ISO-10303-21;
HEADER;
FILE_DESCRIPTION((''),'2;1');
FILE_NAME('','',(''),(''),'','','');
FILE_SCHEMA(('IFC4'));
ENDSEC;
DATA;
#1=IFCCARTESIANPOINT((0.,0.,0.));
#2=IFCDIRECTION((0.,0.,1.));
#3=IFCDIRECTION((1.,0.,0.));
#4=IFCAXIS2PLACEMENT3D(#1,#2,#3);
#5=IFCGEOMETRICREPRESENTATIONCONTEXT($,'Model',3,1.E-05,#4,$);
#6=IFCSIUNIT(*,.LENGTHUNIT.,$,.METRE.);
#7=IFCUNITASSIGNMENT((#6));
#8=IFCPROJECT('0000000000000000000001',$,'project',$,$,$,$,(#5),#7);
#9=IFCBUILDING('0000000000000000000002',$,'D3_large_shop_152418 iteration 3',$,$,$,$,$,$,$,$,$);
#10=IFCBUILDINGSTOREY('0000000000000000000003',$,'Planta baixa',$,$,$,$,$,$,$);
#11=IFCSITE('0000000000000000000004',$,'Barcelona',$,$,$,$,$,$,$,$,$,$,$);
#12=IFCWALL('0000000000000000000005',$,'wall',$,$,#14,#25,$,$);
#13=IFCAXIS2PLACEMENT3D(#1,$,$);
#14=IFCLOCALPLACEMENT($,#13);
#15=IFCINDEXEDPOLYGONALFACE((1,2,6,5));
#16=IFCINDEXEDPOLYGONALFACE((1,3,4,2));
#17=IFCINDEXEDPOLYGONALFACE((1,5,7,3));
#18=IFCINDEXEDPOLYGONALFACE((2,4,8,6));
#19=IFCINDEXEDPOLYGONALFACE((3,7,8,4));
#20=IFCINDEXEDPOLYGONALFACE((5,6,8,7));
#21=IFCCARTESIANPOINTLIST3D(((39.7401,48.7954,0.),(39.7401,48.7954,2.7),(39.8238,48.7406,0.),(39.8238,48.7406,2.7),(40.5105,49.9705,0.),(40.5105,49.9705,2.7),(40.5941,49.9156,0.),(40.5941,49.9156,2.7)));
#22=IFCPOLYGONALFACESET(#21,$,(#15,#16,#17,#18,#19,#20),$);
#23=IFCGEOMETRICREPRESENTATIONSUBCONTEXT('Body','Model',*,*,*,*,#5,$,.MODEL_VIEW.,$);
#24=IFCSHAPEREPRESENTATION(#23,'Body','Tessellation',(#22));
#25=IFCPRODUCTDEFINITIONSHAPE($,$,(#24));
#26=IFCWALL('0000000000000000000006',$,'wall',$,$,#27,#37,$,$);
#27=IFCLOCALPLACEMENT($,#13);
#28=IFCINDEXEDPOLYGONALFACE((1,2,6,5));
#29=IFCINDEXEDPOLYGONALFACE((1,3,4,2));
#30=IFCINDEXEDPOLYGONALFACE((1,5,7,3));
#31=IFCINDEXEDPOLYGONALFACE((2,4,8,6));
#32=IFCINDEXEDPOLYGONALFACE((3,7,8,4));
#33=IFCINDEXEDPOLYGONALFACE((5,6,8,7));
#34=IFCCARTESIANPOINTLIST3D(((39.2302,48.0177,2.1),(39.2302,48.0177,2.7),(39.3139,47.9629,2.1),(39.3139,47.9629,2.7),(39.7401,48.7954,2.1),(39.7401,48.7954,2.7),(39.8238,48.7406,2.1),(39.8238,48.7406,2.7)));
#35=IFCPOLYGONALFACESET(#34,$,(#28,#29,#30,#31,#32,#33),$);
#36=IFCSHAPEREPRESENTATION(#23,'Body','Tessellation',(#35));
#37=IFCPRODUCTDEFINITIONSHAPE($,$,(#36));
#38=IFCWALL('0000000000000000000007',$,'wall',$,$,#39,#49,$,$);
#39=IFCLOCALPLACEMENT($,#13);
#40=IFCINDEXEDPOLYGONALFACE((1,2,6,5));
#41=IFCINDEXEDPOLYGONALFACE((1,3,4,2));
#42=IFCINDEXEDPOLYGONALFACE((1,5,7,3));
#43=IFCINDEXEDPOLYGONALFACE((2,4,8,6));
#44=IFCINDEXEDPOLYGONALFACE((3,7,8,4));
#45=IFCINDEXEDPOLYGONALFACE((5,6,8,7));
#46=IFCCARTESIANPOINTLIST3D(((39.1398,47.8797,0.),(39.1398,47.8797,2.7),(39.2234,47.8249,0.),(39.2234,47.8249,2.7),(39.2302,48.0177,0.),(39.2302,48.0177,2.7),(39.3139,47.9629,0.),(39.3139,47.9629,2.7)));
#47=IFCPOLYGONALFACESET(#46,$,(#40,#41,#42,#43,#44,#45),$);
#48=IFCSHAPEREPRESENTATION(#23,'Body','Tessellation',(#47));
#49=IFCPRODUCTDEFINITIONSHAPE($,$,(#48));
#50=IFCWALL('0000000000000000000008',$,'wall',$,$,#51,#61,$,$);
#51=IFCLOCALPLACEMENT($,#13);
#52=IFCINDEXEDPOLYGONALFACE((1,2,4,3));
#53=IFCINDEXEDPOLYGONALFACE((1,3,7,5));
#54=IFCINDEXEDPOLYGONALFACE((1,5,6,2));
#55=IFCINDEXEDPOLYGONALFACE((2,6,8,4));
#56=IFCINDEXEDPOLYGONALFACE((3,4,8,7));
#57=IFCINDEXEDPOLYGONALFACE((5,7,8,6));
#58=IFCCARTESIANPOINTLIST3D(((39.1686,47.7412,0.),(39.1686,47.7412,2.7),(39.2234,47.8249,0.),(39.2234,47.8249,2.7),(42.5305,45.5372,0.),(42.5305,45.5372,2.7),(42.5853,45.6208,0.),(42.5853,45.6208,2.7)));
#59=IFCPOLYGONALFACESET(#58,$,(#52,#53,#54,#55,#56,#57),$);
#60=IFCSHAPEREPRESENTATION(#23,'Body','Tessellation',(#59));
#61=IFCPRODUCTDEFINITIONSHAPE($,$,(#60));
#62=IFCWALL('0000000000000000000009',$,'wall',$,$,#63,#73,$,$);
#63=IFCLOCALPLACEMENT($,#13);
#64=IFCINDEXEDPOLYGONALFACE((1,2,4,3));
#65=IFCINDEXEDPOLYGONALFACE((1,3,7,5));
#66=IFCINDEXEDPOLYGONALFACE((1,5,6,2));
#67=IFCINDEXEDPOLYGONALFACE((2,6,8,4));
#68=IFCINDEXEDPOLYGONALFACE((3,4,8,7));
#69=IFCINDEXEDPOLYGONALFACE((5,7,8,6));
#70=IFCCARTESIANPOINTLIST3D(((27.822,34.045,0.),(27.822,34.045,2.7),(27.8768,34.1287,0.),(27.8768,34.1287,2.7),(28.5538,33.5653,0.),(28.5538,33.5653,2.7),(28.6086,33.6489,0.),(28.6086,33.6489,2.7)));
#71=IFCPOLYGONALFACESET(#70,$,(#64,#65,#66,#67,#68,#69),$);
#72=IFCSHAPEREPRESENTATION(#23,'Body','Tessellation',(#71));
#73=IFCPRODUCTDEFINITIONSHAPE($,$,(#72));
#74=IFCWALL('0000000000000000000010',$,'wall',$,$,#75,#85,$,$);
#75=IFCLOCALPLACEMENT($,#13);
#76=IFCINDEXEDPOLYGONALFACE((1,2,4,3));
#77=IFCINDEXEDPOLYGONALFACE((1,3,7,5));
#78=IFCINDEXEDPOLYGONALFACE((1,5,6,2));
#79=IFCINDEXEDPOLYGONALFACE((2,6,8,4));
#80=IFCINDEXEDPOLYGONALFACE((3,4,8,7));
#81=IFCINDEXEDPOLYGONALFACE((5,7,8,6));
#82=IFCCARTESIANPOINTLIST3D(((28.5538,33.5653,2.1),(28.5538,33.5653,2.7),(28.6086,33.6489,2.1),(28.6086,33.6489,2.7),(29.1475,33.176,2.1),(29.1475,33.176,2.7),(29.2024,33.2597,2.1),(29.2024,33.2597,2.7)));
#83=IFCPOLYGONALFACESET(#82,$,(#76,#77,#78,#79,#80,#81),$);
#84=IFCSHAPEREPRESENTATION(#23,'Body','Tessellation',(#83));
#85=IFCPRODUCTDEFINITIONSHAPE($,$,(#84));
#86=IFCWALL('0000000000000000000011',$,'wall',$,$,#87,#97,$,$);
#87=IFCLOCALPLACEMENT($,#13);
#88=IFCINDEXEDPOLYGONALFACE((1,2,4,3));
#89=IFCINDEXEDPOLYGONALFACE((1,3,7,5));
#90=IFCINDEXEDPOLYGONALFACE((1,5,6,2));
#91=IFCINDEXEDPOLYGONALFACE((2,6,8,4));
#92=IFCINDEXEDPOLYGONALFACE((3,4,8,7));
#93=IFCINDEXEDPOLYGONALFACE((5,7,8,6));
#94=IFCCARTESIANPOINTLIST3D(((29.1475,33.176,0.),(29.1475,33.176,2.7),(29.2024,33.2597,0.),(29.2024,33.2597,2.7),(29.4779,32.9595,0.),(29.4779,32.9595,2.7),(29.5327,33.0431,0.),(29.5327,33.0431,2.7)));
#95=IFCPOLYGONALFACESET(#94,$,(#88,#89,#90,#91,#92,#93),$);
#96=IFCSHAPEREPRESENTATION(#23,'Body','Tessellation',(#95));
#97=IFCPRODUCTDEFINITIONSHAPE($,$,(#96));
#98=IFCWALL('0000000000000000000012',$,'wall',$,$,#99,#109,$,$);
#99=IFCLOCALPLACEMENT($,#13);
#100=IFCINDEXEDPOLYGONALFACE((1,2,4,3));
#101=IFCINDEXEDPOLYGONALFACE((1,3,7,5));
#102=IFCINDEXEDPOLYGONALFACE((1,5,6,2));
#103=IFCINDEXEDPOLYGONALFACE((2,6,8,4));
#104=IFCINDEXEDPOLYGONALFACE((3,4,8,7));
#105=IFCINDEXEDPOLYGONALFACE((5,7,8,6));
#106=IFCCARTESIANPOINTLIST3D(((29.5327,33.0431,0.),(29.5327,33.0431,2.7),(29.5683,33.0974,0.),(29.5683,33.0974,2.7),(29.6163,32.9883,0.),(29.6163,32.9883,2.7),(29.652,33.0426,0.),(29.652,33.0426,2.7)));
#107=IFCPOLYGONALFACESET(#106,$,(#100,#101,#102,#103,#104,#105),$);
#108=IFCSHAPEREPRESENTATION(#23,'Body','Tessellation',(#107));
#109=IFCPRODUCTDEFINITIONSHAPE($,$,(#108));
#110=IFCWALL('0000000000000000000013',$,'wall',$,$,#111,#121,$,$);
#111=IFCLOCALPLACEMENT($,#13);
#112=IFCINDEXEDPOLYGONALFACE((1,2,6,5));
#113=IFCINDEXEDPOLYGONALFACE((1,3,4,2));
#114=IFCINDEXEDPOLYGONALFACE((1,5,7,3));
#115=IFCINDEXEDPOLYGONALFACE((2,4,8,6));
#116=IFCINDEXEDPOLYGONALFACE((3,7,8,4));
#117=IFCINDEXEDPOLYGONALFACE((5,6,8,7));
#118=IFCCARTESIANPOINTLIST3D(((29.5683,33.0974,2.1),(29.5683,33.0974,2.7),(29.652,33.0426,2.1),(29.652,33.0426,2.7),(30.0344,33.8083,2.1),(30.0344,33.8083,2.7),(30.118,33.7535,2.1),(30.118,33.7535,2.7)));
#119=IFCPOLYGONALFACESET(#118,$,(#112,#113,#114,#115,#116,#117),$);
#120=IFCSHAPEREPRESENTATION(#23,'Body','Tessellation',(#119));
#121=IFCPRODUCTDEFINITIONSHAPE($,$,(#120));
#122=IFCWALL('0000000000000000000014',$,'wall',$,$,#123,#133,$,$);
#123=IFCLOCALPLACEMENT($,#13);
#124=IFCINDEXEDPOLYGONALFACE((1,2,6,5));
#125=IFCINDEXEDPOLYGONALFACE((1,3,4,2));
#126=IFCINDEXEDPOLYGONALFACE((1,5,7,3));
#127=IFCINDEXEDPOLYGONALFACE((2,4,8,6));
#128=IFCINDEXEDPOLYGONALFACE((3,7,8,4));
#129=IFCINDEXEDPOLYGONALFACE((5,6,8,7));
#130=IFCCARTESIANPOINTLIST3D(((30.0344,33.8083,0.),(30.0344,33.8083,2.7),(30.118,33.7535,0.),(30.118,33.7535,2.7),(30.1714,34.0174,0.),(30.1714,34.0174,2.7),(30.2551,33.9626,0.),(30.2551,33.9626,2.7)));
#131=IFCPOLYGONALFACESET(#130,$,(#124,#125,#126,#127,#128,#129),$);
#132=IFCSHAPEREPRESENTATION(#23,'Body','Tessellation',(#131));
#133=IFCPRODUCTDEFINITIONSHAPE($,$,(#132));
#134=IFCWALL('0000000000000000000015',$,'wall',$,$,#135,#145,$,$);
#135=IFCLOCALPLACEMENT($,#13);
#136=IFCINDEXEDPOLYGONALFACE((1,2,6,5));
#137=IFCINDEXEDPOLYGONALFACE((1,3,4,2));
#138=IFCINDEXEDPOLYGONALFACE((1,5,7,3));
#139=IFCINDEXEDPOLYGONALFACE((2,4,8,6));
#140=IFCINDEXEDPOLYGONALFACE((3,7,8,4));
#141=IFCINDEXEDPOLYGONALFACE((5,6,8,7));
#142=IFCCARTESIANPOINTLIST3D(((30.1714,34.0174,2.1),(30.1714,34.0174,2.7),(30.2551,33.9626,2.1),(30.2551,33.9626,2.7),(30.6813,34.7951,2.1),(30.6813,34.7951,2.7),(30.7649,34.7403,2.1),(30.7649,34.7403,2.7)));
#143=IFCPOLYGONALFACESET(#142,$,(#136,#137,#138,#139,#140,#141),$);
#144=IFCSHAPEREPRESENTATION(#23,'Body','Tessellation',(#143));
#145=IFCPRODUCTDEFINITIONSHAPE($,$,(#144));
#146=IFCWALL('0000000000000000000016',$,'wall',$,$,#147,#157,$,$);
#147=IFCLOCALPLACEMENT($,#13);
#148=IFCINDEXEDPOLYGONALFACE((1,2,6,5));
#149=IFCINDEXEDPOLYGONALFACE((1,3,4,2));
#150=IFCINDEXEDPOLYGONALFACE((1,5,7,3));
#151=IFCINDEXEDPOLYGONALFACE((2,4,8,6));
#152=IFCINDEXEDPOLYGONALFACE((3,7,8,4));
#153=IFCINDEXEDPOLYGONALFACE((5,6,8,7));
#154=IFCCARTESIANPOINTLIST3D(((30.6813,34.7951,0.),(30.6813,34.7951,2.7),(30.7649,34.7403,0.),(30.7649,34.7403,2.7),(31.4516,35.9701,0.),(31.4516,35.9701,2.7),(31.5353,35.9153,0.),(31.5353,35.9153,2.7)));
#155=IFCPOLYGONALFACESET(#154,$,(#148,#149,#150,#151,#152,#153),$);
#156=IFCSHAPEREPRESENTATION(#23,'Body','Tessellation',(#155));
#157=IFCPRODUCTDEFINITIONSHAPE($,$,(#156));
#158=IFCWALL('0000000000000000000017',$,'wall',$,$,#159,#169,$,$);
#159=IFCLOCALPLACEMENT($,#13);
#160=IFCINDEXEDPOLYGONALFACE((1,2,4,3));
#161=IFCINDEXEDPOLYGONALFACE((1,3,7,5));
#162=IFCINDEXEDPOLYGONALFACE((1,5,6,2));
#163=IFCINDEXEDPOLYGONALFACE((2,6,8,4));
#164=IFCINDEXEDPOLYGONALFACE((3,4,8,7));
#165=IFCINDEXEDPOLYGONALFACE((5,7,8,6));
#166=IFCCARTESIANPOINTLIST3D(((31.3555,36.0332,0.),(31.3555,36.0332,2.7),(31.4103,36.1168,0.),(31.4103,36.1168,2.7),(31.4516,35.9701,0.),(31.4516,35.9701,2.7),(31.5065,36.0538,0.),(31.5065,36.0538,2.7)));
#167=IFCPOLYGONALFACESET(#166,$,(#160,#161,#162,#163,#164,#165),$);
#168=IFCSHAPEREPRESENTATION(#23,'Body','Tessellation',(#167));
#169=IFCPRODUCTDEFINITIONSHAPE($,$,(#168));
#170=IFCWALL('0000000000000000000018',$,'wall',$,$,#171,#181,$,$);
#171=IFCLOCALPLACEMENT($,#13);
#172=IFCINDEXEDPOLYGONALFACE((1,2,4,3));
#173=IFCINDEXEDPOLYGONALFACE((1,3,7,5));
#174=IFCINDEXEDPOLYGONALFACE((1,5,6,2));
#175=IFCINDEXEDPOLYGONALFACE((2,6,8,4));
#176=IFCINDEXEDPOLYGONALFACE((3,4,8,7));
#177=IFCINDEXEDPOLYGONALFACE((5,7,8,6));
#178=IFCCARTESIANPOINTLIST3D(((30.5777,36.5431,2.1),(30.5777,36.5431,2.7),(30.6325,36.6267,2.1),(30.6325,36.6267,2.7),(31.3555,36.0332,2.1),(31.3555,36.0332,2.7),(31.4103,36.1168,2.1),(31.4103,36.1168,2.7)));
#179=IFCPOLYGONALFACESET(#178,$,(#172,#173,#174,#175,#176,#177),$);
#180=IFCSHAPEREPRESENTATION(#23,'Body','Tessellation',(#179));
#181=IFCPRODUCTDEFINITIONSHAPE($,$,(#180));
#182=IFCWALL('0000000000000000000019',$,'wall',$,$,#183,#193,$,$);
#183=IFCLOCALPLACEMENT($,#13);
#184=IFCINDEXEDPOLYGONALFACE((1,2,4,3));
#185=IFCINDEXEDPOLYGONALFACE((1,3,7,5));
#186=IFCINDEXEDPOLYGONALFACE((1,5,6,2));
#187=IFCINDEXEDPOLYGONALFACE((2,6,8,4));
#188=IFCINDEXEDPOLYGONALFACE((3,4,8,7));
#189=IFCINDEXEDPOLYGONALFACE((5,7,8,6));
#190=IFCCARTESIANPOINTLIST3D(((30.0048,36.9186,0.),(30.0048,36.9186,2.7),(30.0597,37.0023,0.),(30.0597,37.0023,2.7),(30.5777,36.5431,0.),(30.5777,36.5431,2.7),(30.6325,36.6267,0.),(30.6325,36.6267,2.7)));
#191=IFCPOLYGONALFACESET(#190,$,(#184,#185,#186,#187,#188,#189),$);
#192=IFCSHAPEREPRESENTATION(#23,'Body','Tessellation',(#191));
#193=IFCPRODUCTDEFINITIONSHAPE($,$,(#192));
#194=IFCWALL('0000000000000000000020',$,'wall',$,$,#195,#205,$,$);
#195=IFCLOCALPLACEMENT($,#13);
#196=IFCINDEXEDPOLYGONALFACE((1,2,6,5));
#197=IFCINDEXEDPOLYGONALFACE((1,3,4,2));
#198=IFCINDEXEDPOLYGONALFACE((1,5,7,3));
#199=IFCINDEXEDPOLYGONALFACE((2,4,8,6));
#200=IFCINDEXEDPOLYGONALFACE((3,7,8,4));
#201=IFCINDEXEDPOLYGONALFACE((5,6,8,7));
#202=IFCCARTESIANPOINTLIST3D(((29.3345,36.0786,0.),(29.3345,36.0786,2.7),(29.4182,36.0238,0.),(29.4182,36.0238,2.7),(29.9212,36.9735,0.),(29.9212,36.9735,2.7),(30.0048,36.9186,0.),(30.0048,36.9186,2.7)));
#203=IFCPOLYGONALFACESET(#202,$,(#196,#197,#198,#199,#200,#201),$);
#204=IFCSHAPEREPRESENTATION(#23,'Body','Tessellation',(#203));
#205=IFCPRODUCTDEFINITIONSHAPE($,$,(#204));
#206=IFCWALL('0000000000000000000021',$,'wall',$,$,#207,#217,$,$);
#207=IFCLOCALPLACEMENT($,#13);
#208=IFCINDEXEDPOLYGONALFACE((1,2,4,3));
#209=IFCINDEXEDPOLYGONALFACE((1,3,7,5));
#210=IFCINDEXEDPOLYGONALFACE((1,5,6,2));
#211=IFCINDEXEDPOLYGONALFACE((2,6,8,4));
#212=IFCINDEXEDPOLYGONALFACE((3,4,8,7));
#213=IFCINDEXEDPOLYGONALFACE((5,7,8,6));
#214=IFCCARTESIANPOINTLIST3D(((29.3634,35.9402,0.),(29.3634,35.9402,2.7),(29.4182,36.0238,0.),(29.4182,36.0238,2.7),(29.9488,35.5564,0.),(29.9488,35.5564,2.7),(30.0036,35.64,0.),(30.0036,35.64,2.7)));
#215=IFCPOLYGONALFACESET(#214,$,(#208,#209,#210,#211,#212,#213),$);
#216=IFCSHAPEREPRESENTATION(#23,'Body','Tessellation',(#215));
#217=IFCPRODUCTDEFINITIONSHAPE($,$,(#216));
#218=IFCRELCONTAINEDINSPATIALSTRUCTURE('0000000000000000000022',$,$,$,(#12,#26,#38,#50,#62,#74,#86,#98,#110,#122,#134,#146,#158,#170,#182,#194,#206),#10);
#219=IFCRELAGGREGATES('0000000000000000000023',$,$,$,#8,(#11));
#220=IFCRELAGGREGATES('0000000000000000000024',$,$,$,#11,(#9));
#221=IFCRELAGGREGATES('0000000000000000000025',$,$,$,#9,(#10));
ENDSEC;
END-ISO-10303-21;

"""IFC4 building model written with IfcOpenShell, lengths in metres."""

from ifc_helpers import new_model, si_unit, frame, origin, origin_with_axes, place, context, subcontext, project, spatial, polyline, outline, extrude, element, save


model = new_model("IFC4")

# Units and contexts
model_context = context("Model", 3, precision=1e-05, world=origin_with_axes())
body_context = subcontext(model_context, "Body", "Model", "MODEL_VIEW")
ifc_project = project(units=[si_unit("LENGTHUNIT", "METRE")], contexts=[model_context])

# Site, building, storey
site = spatial("IfcSite", under=ifc_project, Name="Barcelona")
building = spatial("IfcBuilding", under=site, Name="D3_large_shop_152418 iteration 3")
storey = spatial("IfcBuildingStorey", under=building, Name="Planta baixa")

# Walls
wall_1_placement = place(None, origin_with_axes())
element("IfcWall", 1, at=wall_1_placement, inside=storey, Name="wall", context=body_context, shape_type="SweptSolid", body=[
    extrude(outline(polyline([(40.5941, 49.9156), (39.8238, 48.7406), (39.7401, 48.7954), (40.5105, 49.9705), (40.5941, 49.9156)])), origin(), (0.0, 0.0, 1.0), 2.7),
])
wall_2_placement = place(None, origin_with_axes())
element("IfcWall", 2, at=wall_2_placement, inside=storey, Name="wall", context=body_context, shape_type="SweptSolid", body=[
    extrude(outline(polyline([(39.8238, 48.7406), (39.3139, 47.9629), (39.2302, 48.0177), (39.7401, 48.7954), (39.8238, 48.7406)])), frame((0.0, 0.0, 2.1)), (0.0, 0.0, 1.0), 0.6),
])
wall_3_placement = place(None, origin_with_axes())
element("IfcWall", 3, at=wall_3_placement, inside=storey, Name="wall", context=body_context, shape_type="SweptSolid", body=[
    extrude(outline(polyline([(39.3139, 47.9629), (39.2234, 47.8249), (39.1398, 47.8797), (39.2302, 48.0177), (39.3139, 47.9629)])), origin(), (0.0, 0.0, 1.0), 2.7),
])
wall_4_placement = place(None, origin_with_axes())
element("IfcWall", 4, at=wall_4_placement, inside=storey, Name="wall", context=body_context, shape_type="SweptSolid", body=[
    extrude(outline(polyline([(39.2234, 47.8249), (42.5853, 45.6208), (42.5305, 45.5372), (39.1686, 47.7412), (39.2234, 47.8249)])), origin(), (0.0, 0.0, 1.0), 2.7),
])
wall_5_placement = place(None, origin_with_axes())
element("IfcWall", 5, at=wall_5_placement, inside=storey, Name="wall", context=body_context, shape_type="SweptSolid", body=[
    extrude(outline(polyline([(27.8768, 34.1287), (28.6086, 33.6489), (28.5538, 33.5653), (27.822, 34.045), (27.8768, 34.1287)])), origin(), (0.0, 0.0, 1.0), 2.7),
])
wall_6_placement = place(None, origin_with_axes())
element("IfcWall", 6, at=wall_6_placement, inside=storey, Name="wall", context=body_context, shape_type="SweptSolid", body=[
    extrude(outline(polyline([(28.6086, 33.6489), (29.2024, 33.2597), (29.1475, 33.176), (28.5538, 33.5653), (28.6086, 33.6489)])), frame((0.0, 0.0, 2.1)), (0.0, 0.0, 1.0), 0.6),
])
wall_7_placement = place(None, origin_with_axes())
element("IfcWall", 7, at=wall_7_placement, inside=storey, Name="wall", context=body_context, shape_type="SweptSolid", body=[
    extrude(outline(polyline([(29.2024, 33.2597), (29.5327, 33.0431), (29.4779, 32.9595), (29.1475, 33.176), (29.2024, 33.2597)])), origin(), (0.0, 0.0, 1.0), 2.7),
])
wall_8_placement = place(None, origin_with_axes())
element("IfcWall", 8, at=wall_8_placement, inside=storey, Name="wall", context=body_context, shape_type="SweptSolid", body=[
    extrude(outline(polyline([(29.5327, 33.0431), (29.5683, 33.0974), (29.652, 33.0426), (29.6163, 32.9883), (29.5327, 33.0431)])), origin(), (0.0, 0.0, 1.0), 2.7),
])
wall_9_placement = place(None, origin_with_axes())
element("IfcWall", 9, at=wall_9_placement, inside=storey, Name="wall", context=body_context, shape_type="SweptSolid", body=[
    extrude(outline(polyline([(29.5683, 33.0974), (30.0344, 33.8083), (30.118, 33.7535), (29.652, 33.0426), (29.5683, 33.0974)])), frame((0.0, 0.0, 2.1)), (0.0, 0.0, 1.0), 0.6),
])
wall_10_placement = place(None, origin_with_axes())
element("IfcWall", 10, at=wall_10_placement, inside=storey, Name="wall", context=body_context, shape_type="SweptSolid", body=[
    extrude(outline(polyline([(30.0344, 33.8083), (30.1714, 34.0174), (30.2551, 33.9626), (30.118, 33.7535), (30.0344, 33.8083)])), origin(), (0.0, 0.0, 1.0), 2.7),
])
wall_11_placement = place(None, origin_with_axes())
element("IfcWall", 11, at=wall_11_placement, inside=storey, Name="wall", context=body_context, shape_type="SweptSolid", body=[
    extrude(outline(polyline([(30.1714, 34.0174), (30.6813, 34.7951), (30.7649, 34.7403), (30.2551, 33.9626), (30.1714, 34.0174)])), frame((0.0, 0.0, 2.1)), (0.0, 0.0, 1.0), 0.6),
])
wall_12_placement = place(None, origin_with_axes())
element("IfcWall", 12, at=wall_12_placement, inside=storey, Name="wall", context=body_context, shape_type="SweptSolid", body=[
    extrude(outline(polyline([(30.6813, 34.7951), (31.4516, 35.9701), (31.5353, 35.9153), (30.7649, 34.7403), (30.6813, 34.7951)])), origin(), (0.0, 0.0, 1.0), 2.7),
])
wall_13_placement = place(None, origin_with_axes())
element("IfcWall", 13, at=wall_13_placement, inside=storey, Name="wall", context=body_context, shape_type="SweptSolid", body=[
    extrude(outline(polyline([(31.4516, 35.9701), (31.3555, 36.0332), (31.4103, 36.1168), (31.5065, 36.0538), (31.4516, 35.9701)])), origin(), (0.0, 0.0, 1.0), 2.7),
])
wall_14_placement = place(None, origin_with_axes())
element("IfcWall", 14, at=wall_14_placement, inside=storey, Name="wall", context=body_context, shape_type="SweptSolid", body=[
    extrude(outline(polyline([(31.3555, 36.0332), (30.5777, 36.5431), (30.6325, 36.6267), (31.4103, 36.1168), (31.3555, 36.0332)])), frame((0.0, 0.0, 2.1)), (0.0, 0.0, 1.0), 0.6),
])
wall_15_placement = place(None, origin_with_axes())
element("IfcWall", 15, at=wall_15_placement, inside=storey, Name="wall", context=body_context, shape_type="SweptSolid", body=[
    extrude(outline(polyline([(30.5777, 36.5431), (30.0048, 36.9186), (30.0597, 37.0023), (30.6325, 36.6267), (30.5777, 36.5431)])), origin(), (0.0, 0.0, 1.0), 2.7),
])
wall_16_placement = place(None, origin_with_axes())
element("IfcWall", 16, at=wall_16_placement, inside=storey, Name="wall", context=body_context, shape_type="SweptSolid", body=[
    extrude(outline(polyline([(30.0048, 36.9186), (29.4182, 36.0238), (29.3345, 36.0786), (29.9212, 36.9735), (30.0048, 36.9186)])), origin(), (0.0, 0.0, 1.0), 2.7),
])
wall_17_placement = place(None, origin_with_axes())
element("IfcWall", 17, at=wall_17_placement, inside=storey, Name="wall", context=body_context, shape_type="SweptSolid", body=[
    extrude(outline(polyline([(29.4182, 36.0238), (30.0036, 35.64), (29.9488, 35.5564), (29.3634, 35.9402), (29.4182, 36.0238)])), origin(), (0.0, 0.0, 1.0), 2.7),
])

save(model, "model.ifc")
